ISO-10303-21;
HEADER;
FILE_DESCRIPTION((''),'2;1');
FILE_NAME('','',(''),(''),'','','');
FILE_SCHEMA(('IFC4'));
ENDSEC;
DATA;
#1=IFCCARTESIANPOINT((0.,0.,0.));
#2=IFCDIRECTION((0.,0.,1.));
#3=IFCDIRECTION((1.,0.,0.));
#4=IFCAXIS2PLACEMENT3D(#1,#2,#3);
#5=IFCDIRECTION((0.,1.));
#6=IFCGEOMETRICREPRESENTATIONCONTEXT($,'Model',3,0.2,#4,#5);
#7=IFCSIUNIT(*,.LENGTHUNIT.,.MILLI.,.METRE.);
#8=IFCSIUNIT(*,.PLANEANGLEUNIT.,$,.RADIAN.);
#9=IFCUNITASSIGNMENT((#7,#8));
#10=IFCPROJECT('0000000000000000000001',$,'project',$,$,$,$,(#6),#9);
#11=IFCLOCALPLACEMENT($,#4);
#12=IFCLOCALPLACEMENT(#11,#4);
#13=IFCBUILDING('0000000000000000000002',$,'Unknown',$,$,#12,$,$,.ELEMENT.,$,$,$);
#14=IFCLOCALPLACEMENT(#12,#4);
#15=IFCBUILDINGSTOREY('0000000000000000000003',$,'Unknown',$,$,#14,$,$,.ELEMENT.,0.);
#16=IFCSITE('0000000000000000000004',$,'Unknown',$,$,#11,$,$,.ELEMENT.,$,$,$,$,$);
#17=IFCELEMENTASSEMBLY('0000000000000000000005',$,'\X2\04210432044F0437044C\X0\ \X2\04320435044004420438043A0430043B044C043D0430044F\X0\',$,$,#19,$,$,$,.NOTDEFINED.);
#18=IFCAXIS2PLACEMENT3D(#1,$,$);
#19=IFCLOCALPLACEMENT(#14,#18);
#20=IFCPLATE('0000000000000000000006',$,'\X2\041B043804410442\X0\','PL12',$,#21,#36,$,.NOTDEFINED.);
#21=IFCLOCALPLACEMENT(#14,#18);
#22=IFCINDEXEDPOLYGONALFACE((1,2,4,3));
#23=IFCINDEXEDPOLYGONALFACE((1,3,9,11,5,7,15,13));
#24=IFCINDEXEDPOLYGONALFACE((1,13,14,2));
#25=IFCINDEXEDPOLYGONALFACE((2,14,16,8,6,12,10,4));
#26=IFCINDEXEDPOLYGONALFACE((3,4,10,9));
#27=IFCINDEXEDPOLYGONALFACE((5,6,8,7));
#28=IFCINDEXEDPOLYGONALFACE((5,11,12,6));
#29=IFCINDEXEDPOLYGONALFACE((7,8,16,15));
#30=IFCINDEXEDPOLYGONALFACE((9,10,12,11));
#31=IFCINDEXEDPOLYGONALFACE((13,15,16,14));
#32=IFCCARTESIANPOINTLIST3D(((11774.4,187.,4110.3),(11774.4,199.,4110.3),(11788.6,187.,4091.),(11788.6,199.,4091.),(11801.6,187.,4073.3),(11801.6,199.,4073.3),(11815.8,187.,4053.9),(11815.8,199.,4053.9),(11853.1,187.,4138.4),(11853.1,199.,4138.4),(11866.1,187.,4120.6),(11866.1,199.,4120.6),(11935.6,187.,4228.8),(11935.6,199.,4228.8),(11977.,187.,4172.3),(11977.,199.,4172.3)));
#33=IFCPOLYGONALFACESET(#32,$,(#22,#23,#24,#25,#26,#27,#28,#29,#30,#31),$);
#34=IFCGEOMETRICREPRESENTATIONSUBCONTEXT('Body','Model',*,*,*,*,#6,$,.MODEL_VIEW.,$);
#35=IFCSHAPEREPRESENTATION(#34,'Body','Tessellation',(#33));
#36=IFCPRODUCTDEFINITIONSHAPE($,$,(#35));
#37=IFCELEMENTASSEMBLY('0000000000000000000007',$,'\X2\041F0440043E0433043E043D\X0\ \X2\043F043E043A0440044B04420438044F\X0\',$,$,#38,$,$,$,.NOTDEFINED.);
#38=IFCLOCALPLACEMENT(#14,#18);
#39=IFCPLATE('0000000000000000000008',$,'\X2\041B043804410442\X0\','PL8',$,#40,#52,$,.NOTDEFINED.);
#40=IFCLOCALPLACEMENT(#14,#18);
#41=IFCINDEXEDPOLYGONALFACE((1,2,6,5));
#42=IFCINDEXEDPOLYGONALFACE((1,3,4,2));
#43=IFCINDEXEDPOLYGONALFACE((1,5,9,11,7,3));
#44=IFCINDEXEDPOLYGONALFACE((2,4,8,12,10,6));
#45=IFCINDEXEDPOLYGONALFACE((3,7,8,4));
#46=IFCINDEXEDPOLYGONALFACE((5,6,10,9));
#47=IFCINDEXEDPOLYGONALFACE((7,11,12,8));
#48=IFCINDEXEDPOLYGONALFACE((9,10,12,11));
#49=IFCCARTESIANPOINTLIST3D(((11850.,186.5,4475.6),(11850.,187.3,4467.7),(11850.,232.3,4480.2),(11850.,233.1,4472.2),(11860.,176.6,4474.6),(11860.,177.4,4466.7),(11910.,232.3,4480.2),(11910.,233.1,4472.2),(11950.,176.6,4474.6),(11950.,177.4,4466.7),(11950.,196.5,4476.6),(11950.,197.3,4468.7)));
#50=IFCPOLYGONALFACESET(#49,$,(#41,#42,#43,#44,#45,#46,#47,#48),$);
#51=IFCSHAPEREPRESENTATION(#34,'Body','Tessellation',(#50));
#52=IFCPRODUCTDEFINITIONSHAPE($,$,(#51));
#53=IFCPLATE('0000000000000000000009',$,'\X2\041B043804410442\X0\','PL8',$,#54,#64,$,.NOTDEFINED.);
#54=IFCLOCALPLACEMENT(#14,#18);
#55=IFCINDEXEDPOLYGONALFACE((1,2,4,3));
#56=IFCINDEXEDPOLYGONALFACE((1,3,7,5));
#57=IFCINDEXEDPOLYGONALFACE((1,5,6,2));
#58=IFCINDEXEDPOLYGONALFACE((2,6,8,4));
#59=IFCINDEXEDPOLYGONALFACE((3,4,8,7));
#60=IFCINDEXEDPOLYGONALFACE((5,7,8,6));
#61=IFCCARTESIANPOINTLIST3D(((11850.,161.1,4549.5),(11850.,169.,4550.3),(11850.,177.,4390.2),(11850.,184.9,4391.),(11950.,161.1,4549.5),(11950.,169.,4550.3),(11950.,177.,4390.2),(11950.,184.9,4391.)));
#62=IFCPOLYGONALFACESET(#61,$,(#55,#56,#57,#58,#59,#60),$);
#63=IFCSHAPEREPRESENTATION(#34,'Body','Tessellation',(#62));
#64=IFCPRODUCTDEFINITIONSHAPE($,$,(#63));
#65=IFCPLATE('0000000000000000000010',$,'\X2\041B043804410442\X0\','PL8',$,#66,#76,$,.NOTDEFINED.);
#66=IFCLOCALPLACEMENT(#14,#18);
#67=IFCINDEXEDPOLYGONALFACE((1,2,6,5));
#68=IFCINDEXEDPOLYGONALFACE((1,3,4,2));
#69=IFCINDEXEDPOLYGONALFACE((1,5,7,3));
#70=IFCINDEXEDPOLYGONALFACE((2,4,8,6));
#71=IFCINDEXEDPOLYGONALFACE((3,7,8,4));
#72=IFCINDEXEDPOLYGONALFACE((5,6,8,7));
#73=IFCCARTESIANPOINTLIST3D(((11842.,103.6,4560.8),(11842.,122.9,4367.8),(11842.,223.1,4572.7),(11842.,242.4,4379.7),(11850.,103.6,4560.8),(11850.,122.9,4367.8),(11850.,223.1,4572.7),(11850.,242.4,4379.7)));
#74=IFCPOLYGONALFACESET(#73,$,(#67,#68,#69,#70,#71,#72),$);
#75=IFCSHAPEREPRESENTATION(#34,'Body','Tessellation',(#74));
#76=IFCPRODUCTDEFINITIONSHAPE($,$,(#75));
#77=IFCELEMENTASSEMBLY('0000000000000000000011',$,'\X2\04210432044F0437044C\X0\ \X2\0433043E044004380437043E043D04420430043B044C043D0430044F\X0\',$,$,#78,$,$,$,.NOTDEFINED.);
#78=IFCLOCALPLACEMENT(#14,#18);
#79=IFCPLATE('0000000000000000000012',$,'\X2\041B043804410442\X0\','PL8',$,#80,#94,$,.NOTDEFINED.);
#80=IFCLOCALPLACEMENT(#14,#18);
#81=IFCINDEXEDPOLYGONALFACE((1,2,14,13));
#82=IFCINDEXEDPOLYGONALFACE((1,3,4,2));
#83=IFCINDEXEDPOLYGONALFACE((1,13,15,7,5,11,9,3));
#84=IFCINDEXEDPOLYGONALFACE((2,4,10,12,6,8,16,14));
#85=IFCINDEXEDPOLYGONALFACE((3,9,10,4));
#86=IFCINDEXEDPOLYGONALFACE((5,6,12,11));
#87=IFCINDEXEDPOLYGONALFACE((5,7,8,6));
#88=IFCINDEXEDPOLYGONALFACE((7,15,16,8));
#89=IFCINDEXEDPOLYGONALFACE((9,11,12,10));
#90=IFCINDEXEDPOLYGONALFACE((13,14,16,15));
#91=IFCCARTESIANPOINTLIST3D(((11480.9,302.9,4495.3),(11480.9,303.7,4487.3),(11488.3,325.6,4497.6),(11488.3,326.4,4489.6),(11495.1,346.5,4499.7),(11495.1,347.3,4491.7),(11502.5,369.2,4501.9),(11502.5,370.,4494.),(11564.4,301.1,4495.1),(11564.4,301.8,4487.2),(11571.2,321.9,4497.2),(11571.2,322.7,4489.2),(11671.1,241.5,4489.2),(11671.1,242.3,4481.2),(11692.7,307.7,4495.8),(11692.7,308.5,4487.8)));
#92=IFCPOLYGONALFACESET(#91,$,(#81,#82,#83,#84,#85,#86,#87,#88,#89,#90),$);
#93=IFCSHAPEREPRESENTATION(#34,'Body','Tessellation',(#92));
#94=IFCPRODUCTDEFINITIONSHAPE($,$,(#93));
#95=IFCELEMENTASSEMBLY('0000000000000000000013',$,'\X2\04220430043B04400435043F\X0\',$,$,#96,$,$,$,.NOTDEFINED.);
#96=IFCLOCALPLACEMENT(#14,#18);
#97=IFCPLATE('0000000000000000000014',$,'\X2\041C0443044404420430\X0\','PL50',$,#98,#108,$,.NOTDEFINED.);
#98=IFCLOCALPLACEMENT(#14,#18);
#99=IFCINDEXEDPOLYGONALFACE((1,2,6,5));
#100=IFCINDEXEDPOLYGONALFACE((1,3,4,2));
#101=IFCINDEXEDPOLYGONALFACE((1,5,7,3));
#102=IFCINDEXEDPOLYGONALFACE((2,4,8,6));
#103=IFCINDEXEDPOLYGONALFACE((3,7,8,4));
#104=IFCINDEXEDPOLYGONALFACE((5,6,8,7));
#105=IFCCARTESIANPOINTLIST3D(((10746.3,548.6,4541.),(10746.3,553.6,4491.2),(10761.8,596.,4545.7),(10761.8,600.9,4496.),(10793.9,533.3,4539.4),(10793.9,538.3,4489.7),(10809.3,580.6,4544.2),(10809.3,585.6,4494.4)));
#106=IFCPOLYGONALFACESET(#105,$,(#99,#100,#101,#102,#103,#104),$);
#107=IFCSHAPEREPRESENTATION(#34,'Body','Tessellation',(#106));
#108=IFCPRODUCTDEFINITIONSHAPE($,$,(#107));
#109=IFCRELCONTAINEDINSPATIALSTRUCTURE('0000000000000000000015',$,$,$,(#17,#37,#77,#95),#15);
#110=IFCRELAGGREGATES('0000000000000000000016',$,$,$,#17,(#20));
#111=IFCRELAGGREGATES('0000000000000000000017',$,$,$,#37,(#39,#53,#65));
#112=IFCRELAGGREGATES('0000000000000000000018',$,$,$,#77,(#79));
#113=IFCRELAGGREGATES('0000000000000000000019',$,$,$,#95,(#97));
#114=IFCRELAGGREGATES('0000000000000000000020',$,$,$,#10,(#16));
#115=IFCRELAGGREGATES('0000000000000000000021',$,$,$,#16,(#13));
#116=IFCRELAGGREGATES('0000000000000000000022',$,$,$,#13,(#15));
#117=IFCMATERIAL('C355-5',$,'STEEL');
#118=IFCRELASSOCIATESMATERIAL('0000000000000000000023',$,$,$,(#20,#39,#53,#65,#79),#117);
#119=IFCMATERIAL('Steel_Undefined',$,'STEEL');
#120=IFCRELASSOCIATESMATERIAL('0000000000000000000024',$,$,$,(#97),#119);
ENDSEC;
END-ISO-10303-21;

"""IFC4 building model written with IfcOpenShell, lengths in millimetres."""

from ifc_helpers import new_model, si_unit, direction, frame, origin_with_axes, place, context, subcontext, project, spatial, line, indexed_curve, outline, extrude, material, element, aggregate, save


model = new_model("IFC4")

# Units and contexts
model_context = context("Model", 3, precision=0.2, world=origin_with_axes(), true_north=direction((0.0, 1.0)))
body_context = subcontext(model_context, "Body", "Model", "MODEL_VIEW")
ifc_project = project(units=[si_unit("LENGTHUNIT", "METRE", prefix="MILLI"), si_unit("PLANEANGLEUNIT", "RADIAN")], contexts=[model_context])

# Site, building, storey
site_placement = place(None, origin_with_axes())
site = spatial("IfcSite", under=ifc_project, at=site_placement, Name="Unknown", CompositionType="ELEMENT")
building_placement = place(site_placement, origin_with_axes())
building = spatial("IfcBuilding", under=site, at=building_placement, Name="Unknown", CompositionType="ELEMENT")
storey_placement = place(building_placement, origin_with_axes())
storey = spatial("IfcBuildingStorey", under=building, at=storey_placement, Name="Unknown", CompositionType="ELEMENT", Elevation=0.0)

# Shared definitions
ifc_material_1 = material(Name="C355-5", Category="STEEL")

# Shared definitions
ifc_material_2 = material(Name="Steel_Undefined", Category="STEEL")

# Element assembly, plate
assembly_1_placement = place(storey_placement, frame((7128.3, 193.0, 653.8), z_axis=(0.0, -1.0, 0.0), x_axis=(0.805914, 0.0, 0.592033)))
assembly_1 = element("IfcElementAssembly", 1, at=assembly_1_placement, inside=storey, Name="Связь вертикальная", PredefinedType="NOTDEFINED")
plate_1_placement = place(assembly_1_placement, frame((5790.7, 35.0, 0.0), z_axis=(0.0, 0.0, -1.0), x_axis=(1.0, 0.0, 0.0)))
plate_1 = element("IfcPlate", 2, at=plate_1_placement, material=ifc_material_1, Name="Лист", Description="PL12", PredefinedType="NOTDEFINED", context=body_context, shape_type="SolidModel", body=[
    extrude(outline(indexed_curve([(0.0, 0.0), (200.0, 0.0), (200.0, 70.0), (0.0, 70.0), (0.0, 46.0), (80.0, 46.0), (80.0, 24.0), (0.0, 24.0)], segments=[line(1, 2, 3, 4, 5, 6, 7, 8, 1)])), frame((0.0, 0.0, 6.0), z_axis=(0.0, 0.0, 1.0), x_axis=(1.0, 0.0, 0.0)), (0.0, 0.0, -1.0), 12.0),
])
aggregate(assembly_1, [plate_1])

# Element assembly, plates
assembly_2_placement = place(storey_placement, frame((6000.0, 173.0, 4470.2), z_axis=(0.0, 0.995037, 0.099504), x_axis=(1.0, 0.0, 0.0)))
assembly_2 = element("IfcElementAssembly", 3, at=assembly_2_placement, inside=storey, Name="Прогон покрытия", PredefinedType="NOTDEFINED")
plate_2_placement = place(assembly_2_placement, frame((5950.0, 0.0, 60.0), z_axis=(0.0, 1.0, 0.0), x_axis=(0.0, 0.0, -1.0)))
plate_2 = element("IfcPlate", 4, at=plate_2_placement, material=ifc_material_1, Name="Лист", Description="PL8", PredefinedType="NOTDEFINED", context=body_context, shape_type="SolidModel", body=[
    extrude(outline(indexed_curve([(0.0, 40.0), (36.0, 0.0), (56.0, 0.0), (56.0, 90.0), (46.0, 100.0), (0.0, 100.0)], segments=[line(1, 2, 3, 4, 5, 6, 1)])), frame((0.0, 0.0, 4.0), z_axis=(0.0, 0.0, 1.0), x_axis=(1.0, 0.0, 0.0)), (0.0, 0.0, -1.0), 8.0),
])
plate_3_placement = place(assembly_2_placement, frame((5950.0, 80.0, 0.0), z_axis=(0.0, 0.0, -1.0), x_axis=(0.0, -1.0, 0.0)))
plate_3 = element("IfcPlate", 5, at=plate_3_placement, material=ifc_material_1, Name="Лист", Description="PL8", PredefinedType="NOTDEFINED", context=body_context, shape_type="SolidModel", body=[
    extrude(outline(indexed_curve([(0.0, 0.0), (160.0, 0.0), (160.0, 100.0), (0.0, 100.0)], segments=[line(1, 2, 3, 4, 1)])), frame((0.0, 0.0, 4.0), z_axis=(0.0, 0.0, 1.0), x_axis=(1.0, 0.0, 0.0)), (0.0, 0.0, -1.0), 8.0),
])
plate_4_placement = place(assembly_2_placement, frame((5846.0, 97.0, -60.0), z_axis=(1.0, 0.0, 0.0), x_axis=(0.0, 0.0, 1.0)))
plate_4 = element("IfcPlate", 6, at=plate_4_placement, material=ifc_material_1, Name="Лист", Description="PL8", PredefinedType="NOTDEFINED", context=body_context, shape_type="SolidModel", body=[
    extrude(outline(indexed_curve([(0.0, 0.0), (120.0, 0.0), (120.0, 194.0), (0.0, 194.0)], segments=[line(1, 2, 3, 4, 1)])), frame((0.0, 0.0, 4.0), z_axis=(0.0, 0.0, 1.0), x_axis=(1.0, 0.0, 0.0)), (0.0, 0.0, -1.0), 8.0),
])
aggregate(assembly_2, [plate_2, plate_3, plate_4])

# Element assemblies, plates
assembly_3_placement = place(storey_placement, frame((10668.4, 602.5, 4521.2), z_axis=(-0.308855, -0.946389, -0.094639), x_axis=(0.951109, -0.307322, -0.030732)))
assembly_3 = element("IfcElementAssembly", 7, at=assembly_3_placement, inside=storey, Name="Связь горизонтальная", PredefinedType="NOTDEFINED")
plate_5_placement = place(assembly_3_placement, frame((865.6, 0.0, -35.0), z_axis=(0.0, -1.0, 0.0), x_axis=(1.0, 0.0, 0.0)))
plate_5 = element("IfcPlate", 8, at=plate_5_placement, material=ifc_material_1, Name="Лист", Description="PL8", PredefinedType="NOTDEFINED", context=body_context, shape_type="SolidModel", body=[
    extrude(outline(indexed_curve([(0.0, 0.0), (200.0, 0.0), (200.0, 70.0), (0.0, 70.0), (0.0, 46.0), (80.0, 46.0), (80.0, 24.0), (0.0, 24.0)], segments=[line(1, 2, 3, 4, 5, 6, 7, 8, 1)])), frame((0.0, 0.0, 4.0), z_axis=(0.0, 0.0, 1.0), x_axis=(1.0, 0.0, 0.0)), (0.0, 0.0, -1.0), 8.0),
])
aggregate(assembly_3, [plate_5])
assembly_4_placement = place(storey_placement, frame((10770.1, 541.0, 4540.2), z_axis=(-0.951109, 0.307322, 0.030732), x_axis=(0.308855, 0.946389, 0.094639)))
assembly_4 = element("IfcElementAssembly", 9, at=assembly_4_placement, inside=storey, Name="Талреп", PredefinedType="NOTDEFINED")
plate_6_placement = place(assembly_4_placement, origin_with_axes())
plate_6 = element("IfcPlate", 10, at=plate_6_placement, material=ifc_material_2, Name="Муфта", Description="PL50", PredefinedType="NOTDEFINED", context=body_context, shape_type="SolidModel", body=[
    extrude(outline(indexed_curve([(0.0, 0.0), (50.0, 0.0), (50.0, 50.0), (0.0, 50.0)], segments=[line(1, 2, 3, 4, 1)])), frame((0.0, 0.0, 25.0), z_axis=(0.0, 0.0, 1.0), x_axis=(1.0, 0.0, 0.0)), (0.0, 0.0, -1.0), 50.0),
])
aggregate(assembly_4, [plate_6])

save(model, "model.ifc")
